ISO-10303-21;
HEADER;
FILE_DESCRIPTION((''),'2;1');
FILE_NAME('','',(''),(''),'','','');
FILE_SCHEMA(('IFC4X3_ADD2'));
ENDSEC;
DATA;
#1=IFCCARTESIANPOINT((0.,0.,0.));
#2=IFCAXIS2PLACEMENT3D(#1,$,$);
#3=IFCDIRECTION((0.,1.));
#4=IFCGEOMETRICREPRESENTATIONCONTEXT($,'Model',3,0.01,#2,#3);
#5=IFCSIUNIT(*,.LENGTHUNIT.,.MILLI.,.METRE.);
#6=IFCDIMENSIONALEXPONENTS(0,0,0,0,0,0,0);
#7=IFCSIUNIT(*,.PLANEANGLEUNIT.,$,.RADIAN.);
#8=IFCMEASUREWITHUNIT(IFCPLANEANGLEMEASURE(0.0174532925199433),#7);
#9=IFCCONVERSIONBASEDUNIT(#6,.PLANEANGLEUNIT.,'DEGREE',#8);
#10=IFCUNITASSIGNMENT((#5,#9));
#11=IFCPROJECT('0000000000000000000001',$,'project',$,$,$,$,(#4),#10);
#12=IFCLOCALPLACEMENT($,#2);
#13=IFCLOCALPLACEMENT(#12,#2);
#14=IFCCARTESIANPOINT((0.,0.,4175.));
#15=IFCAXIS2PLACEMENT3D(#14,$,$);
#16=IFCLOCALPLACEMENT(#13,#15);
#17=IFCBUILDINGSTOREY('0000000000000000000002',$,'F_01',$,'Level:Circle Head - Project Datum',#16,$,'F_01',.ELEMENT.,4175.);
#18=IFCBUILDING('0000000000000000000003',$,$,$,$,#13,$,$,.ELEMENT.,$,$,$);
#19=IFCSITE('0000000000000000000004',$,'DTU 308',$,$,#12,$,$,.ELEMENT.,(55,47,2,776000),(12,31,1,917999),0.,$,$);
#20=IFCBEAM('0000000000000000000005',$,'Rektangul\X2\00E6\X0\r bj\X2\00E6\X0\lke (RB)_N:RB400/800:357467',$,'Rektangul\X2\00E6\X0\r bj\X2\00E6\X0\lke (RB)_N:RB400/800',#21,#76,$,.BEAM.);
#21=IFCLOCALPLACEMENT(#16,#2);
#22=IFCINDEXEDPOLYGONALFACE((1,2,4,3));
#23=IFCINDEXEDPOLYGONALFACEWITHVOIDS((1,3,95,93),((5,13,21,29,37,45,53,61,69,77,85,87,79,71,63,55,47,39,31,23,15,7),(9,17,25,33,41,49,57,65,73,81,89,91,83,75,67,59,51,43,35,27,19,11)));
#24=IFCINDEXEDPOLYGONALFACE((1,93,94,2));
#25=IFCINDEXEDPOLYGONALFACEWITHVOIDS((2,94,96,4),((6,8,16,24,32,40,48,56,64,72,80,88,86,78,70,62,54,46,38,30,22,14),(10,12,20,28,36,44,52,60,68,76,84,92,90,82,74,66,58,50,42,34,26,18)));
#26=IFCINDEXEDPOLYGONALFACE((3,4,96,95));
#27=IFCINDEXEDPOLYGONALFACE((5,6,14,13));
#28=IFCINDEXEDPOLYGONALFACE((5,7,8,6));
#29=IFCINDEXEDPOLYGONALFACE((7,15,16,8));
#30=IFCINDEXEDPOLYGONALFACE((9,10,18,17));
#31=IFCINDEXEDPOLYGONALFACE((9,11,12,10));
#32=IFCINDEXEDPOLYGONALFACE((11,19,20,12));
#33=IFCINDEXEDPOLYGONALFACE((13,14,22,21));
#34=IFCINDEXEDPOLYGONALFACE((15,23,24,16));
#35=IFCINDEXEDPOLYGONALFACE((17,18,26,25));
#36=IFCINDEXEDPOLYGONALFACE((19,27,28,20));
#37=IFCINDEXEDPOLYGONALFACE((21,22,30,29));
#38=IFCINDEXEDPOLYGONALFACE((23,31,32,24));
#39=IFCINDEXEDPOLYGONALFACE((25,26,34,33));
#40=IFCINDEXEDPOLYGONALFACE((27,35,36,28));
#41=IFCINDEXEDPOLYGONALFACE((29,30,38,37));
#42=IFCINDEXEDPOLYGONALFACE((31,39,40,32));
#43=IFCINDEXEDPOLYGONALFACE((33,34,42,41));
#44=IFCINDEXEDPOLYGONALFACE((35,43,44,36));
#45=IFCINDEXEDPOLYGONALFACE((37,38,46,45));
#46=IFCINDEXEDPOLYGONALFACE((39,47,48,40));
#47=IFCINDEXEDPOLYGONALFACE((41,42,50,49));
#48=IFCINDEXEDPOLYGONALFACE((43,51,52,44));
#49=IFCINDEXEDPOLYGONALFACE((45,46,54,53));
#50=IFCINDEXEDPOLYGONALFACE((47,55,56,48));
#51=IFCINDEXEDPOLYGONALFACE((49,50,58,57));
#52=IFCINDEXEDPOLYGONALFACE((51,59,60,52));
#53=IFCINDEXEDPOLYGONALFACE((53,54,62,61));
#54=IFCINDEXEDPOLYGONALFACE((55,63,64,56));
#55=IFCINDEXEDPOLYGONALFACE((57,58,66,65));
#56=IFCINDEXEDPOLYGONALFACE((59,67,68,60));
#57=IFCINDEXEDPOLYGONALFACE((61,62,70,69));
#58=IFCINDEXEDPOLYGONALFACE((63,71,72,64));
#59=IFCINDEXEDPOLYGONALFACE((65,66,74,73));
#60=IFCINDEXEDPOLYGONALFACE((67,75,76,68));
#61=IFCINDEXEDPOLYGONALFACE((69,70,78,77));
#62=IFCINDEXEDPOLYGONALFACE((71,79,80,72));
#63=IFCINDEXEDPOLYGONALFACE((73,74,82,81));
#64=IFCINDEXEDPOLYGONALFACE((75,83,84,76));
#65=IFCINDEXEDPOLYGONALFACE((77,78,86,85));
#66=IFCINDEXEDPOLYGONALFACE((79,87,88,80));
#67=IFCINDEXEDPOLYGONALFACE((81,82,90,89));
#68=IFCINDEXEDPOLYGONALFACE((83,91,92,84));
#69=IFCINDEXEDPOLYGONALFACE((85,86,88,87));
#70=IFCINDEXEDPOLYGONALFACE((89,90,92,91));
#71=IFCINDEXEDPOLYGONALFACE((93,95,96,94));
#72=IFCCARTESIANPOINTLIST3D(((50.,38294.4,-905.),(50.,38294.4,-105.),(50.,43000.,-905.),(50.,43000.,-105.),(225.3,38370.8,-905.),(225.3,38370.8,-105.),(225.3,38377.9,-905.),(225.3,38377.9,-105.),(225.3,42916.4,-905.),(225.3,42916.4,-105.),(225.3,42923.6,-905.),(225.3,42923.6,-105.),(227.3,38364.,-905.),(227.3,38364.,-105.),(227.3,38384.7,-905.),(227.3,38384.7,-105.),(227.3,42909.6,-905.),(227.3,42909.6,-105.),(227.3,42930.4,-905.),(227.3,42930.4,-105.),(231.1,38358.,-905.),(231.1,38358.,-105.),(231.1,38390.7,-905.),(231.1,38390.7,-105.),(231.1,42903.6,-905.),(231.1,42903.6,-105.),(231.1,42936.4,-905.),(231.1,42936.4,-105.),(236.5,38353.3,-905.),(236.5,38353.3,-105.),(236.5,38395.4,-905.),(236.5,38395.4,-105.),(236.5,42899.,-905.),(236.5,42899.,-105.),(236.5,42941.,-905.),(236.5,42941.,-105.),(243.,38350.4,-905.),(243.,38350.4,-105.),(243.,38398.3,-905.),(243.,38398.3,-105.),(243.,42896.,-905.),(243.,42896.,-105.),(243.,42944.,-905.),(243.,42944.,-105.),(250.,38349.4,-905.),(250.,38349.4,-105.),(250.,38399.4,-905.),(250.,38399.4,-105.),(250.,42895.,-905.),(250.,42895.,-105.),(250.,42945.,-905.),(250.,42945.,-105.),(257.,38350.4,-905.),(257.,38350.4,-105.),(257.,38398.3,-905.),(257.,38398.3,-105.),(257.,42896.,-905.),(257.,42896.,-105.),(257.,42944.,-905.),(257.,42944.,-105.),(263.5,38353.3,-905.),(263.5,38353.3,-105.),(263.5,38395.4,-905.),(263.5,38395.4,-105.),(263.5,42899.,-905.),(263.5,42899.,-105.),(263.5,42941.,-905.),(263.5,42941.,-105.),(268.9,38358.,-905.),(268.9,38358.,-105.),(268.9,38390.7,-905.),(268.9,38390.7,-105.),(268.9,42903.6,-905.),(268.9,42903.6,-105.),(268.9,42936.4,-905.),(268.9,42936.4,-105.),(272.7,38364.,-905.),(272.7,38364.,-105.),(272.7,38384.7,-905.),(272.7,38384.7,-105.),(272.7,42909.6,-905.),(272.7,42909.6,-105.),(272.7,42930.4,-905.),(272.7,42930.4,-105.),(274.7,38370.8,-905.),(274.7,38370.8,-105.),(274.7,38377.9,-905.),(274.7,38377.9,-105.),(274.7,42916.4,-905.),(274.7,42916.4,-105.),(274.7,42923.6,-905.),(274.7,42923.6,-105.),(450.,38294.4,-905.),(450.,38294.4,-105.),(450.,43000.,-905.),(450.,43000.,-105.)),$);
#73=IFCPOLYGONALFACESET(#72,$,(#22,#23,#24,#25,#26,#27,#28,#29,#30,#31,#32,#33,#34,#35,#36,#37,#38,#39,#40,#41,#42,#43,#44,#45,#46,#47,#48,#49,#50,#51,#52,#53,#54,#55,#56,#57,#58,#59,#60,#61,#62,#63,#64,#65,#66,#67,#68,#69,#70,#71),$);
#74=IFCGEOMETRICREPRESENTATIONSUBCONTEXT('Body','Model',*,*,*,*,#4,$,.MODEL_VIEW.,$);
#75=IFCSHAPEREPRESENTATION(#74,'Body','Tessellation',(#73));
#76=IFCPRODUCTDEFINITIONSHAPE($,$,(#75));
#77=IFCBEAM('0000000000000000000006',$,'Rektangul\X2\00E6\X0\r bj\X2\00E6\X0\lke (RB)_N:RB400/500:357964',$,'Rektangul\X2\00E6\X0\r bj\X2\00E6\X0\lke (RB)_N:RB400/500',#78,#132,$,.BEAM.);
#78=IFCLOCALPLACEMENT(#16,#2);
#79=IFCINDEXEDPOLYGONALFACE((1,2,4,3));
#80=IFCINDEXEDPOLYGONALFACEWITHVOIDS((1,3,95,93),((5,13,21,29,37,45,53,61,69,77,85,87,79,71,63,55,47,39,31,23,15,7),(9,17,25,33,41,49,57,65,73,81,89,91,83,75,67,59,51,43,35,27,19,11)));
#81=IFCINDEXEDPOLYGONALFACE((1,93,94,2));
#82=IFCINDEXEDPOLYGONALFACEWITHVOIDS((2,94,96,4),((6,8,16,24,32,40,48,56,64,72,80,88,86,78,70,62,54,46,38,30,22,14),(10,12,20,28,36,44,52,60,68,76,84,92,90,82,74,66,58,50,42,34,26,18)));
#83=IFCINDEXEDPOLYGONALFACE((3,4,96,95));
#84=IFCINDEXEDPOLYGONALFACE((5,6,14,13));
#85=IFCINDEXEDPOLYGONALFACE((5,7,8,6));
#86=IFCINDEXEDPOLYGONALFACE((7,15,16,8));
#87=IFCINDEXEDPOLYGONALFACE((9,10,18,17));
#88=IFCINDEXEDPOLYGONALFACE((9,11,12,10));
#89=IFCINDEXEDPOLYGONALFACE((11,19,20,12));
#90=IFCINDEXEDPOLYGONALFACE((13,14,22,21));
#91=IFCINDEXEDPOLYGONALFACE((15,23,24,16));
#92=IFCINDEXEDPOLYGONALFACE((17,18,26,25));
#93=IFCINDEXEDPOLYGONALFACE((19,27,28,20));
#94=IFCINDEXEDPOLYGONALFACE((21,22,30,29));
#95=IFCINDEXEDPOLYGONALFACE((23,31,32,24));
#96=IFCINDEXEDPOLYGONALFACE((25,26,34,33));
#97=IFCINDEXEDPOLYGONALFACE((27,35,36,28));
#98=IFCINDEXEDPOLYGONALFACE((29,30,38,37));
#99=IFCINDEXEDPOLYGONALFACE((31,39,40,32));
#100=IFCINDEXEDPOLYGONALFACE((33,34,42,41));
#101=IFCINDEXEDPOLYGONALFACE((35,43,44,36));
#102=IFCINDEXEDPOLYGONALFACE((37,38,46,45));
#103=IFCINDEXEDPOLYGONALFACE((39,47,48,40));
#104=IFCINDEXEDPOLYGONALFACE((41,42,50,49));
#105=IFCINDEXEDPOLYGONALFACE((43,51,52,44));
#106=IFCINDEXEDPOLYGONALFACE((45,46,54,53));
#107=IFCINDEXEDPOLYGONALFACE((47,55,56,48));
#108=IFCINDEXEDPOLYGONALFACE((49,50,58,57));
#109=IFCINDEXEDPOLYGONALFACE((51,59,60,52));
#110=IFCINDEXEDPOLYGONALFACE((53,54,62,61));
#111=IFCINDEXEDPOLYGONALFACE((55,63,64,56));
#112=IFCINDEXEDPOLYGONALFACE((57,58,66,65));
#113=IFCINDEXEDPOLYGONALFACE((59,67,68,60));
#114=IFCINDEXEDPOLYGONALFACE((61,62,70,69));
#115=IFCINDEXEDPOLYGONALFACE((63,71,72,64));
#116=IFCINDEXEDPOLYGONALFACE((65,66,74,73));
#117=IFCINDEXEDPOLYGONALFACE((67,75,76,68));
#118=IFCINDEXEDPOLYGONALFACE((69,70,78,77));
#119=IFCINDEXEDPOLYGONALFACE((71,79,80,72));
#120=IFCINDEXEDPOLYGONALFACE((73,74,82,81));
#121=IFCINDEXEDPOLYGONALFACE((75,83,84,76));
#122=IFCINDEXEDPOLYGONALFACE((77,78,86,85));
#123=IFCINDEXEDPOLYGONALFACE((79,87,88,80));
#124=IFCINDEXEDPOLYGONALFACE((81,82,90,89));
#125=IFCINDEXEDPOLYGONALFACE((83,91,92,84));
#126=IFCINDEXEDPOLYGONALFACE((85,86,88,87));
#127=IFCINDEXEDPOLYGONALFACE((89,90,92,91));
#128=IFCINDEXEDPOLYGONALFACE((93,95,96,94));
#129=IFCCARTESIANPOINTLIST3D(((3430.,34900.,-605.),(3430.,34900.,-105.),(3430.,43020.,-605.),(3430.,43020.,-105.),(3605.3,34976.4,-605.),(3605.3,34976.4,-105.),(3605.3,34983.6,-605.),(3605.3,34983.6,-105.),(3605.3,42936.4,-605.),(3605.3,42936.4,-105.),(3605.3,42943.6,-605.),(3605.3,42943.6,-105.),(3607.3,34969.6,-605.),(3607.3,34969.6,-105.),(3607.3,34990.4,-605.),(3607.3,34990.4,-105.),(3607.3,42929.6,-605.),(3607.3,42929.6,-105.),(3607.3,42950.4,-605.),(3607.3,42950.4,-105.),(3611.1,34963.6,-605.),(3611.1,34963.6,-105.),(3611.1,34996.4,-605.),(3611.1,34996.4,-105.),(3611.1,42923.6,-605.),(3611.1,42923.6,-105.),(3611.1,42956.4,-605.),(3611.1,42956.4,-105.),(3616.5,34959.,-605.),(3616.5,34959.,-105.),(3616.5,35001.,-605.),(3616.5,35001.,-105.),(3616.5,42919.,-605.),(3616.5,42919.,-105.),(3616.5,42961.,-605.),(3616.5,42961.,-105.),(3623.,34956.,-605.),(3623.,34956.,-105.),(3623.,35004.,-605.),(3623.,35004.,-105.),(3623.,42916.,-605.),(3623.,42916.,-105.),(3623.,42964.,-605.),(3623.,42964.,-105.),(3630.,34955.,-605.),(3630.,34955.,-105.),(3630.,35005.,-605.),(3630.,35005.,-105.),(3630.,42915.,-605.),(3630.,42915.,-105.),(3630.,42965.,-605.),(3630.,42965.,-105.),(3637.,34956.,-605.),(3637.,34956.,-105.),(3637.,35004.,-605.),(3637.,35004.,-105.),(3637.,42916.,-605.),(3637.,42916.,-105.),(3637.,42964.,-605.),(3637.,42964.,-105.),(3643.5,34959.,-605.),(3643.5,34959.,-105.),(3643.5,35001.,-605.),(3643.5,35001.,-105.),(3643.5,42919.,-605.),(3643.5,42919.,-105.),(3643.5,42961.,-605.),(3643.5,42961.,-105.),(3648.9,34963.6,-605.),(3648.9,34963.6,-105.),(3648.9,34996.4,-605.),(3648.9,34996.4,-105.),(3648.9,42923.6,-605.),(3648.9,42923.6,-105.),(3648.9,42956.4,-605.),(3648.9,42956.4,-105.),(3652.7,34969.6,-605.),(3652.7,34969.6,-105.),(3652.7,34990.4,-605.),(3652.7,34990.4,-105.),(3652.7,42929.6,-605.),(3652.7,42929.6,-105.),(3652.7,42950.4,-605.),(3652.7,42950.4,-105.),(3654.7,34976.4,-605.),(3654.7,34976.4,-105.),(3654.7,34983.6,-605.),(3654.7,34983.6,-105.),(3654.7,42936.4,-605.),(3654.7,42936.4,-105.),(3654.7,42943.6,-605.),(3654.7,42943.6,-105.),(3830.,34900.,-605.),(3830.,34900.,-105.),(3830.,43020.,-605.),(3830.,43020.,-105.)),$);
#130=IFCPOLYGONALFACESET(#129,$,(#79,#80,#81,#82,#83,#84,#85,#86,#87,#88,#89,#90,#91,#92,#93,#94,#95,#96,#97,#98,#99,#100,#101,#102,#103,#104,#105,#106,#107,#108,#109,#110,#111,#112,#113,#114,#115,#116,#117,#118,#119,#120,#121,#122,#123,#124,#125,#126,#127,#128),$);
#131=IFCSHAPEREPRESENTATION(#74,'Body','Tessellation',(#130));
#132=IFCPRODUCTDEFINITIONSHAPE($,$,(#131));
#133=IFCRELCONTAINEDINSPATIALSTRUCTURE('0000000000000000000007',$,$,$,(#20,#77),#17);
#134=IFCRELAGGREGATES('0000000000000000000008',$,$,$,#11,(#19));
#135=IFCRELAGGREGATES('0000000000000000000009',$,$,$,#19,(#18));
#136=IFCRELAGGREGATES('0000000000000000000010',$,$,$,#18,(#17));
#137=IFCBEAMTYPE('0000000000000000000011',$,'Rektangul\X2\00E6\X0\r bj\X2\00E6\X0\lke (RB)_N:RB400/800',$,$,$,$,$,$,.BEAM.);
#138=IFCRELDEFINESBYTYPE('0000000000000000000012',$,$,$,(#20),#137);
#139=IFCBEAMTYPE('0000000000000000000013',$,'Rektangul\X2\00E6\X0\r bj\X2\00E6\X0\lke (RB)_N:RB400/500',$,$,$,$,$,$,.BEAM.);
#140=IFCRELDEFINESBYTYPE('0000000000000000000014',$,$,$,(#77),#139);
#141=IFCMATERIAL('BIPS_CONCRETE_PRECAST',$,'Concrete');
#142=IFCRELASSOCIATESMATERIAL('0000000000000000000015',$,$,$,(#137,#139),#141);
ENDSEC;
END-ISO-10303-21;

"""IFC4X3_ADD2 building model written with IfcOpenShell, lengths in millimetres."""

from ifc_helpers import new_model, entity, si_unit, converted_unit, direction, frame, frame_2d, origin, place, context, subcontext, project, spatial, polyline, circle_curve, parameter, trimmed, segment, composite_curve, outline, extrude, source, transform, mapped, material, material_profile, profile_set, type_object, type_shapes, element, save


model = new_model("IFC4X3_ADD2")

# Units and contexts
model_context = context("Model", 3, precision=0.01, world=origin(), true_north=direction((0.0, 1.0)))
body_context = subcontext(model_context, "Body", "Model", "MODEL_VIEW")
ifc_project = project(units=[si_unit("LENGTHUNIT", "METRE", prefix="MILLI"), converted_unit("PLANEANGLEUNIT", "DEGREE", entity("IfcPlaneAngleMeasure", 0.0174532925199433), si_unit("PLANEANGLEUNIT", "RADIAN"), dimensions=[0, 0, 0, 0, 0, 0, 0])], contexts=[model_context])

# Site, building, storey
site_placement = place(None, origin())
site = spatial("IfcSite", under=ifc_project, at=site_placement, Name="DTU 308", CompositionType="ELEMENT", RefLatitude=(55, 47, 2, 776000), RefLongitude=(12, 31, 1, 917999), RefElevation=0.0)
building_placement = place(site_placement, origin())
building = spatial("IfcBuilding", under=site, at=building_placement, CompositionType="ELEMENT")
storey_placement = place(building_placement, frame((0.0, 0.0, 4175.0)))
storey = spatial("IfcBuildingStorey", under=building, at=storey_placement, Name="F_01", ObjectType="Level:Circle Head - Project Datum", LongName="F_01", CompositionType="ELEMENT", Elevation=4175.0)

# Beams
ifc_material_1 = material(Name="BIPS_CONCRETE_PRECAST", Category="Concrete")
ifc_material_profile_1 = material_profile(ifc_material_1, outline(polyline([(-2352.8, -200.0), (2352.8, -200.0), (2352.8, 200.0), (-2352.8, 200.0), (-2352.8, -200.0)]), holes=[composite_curve([segment(trimmed(circle_curve(frame_2d((2272.8, 0.0), x_axis=(-1.0, 0.0)), 25.0), [parameter(0.0)], [parameter(180.0)], True, "PARAMETER"), False, "CONTINUOUS"), segment(trimmed(circle_curve(frame_2d((2272.8, 0.0), x_axis=(-1.0, 0.0)), 25.0), [parameter(180.0)], [parameter(360.0)], True, "PARAMETER"), False, "CONTINUOUS")], self_intersect=False), composite_curve([segment(trimmed(circle_curve(frame_2d((-2272.8, 0.0), x_axis=(-1.0, 0.0)), 25.0), [parameter(0.0)], [parameter(180.0)], True, "PARAMETER"), False, "CONTINUOUS"), segment(trimmed(circle_curve(frame_2d((-2272.8, 0.0), x_axis=(-1.0, 0.0)), 25.0), [parameter(180.0)], [parameter(360.0)], True, "PARAMETER"), False, "CONTINUOUS")], self_intersect=False)]), Name="RB400/800")
ifc_profile_set_1 = profile_set([ifc_material_profile_1], Name="RB400/800")
beam_type_1 = type_object("IfcBeamType", Name="Rektangulær bjælke (RB)_N:RB400/800", PredefinedType="BEAM", material=ifc_profile_set_1)
shared_shape_1 = source(origin(), body_context, "Body", "SweptSolid", [
    extrude(outline(polyline([(-2352.8, -200.0), (2352.8, -200.0), (2352.8, 200.0), (-2352.8, 200.0), (-2352.8, -200.0)]), holes=[composite_curve([segment(trimmed(circle_curve(frame_2d((2272.8, 0.0), x_axis=(-1.0, 0.0)), 25.0), [parameter(0.0)], [parameter(180.0)], True, "PARAMETER"), False, "CONTINUOUS"), segment(trimmed(circle_curve(frame_2d((2272.8, 0.0), x_axis=(-1.0, 0.0)), 25.0), [parameter(180.0)], [parameter(360.0)], True, "PARAMETER"), False, "CONTINUOUS")], self_intersect=False), composite_curve([segment(trimmed(circle_curve(frame_2d((-2272.8, 0.0), x_axis=(-1.0, 0.0)), 25.0), [parameter(0.0)], [parameter(180.0)], True, "PARAMETER"), False, "CONTINUOUS"), segment(trimmed(circle_curve(frame_2d((-2272.8, 0.0), x_axis=(-1.0, 0.0)), 25.0), [parameter(180.0)], [parameter(360.0)], True, "PARAMETER"), False, "CONTINUOUS")], self_intersect=False)]), frame((-16.7, 0.0, -400.0), z_axis=(0.0, 0.0, 1.0), x_axis=(-1.0, 0.0, 0.0)), (0.0, 0.0, 1.0), 800.0),
])
type_shapes(beam_type_1, [shared_shape_1])
beam_1_placement = place(storey_placement, frame((250.0, 40663.8, -505.0), z_axis=(0.0, 0.0, 1.0), x_axis=(0.0, 1.0, 0.0)))
element("IfcBeam", 1, at=beam_1_placement, inside=storey, type_object=beam_type_1, Name="Rektangulær bjælke (RB)_N:RB400/800:357467", ObjectType="Rektangulær bjælke (RB)_N:RB400/800", PredefinedType="BEAM", context=body_context, shape_type="MappedRepresentation", body=[
    mapped(shared_shape_1, transform((0.0, 0.0, 0.0), scale=1.0)),
])
ifc_material_profile_2 = material_profile(ifc_material_1, outline(polyline([(-4060.0, -200.0), (4060.0, -200.0), (4060.0, 200.0), (-4060.0, 200.0), (-4060.0, -200.0)]), holes=[composite_curve([segment(trimmed(circle_curve(frame_2d((3980.0, 0.0), x_axis=(-1.0, 0.0)), 25.0), [parameter(0.0)], [parameter(180.0)], True, "PARAMETER"), False, "CONTINUOUS"), segment(trimmed(circle_curve(frame_2d((3980.0, 0.0), x_axis=(-1.0, 0.0)), 25.0), [parameter(180.0)], [parameter(360.0)], True, "PARAMETER"), False, "CONTINUOUS")], self_intersect=False), composite_curve([segment(trimmed(circle_curve(frame_2d((-3980.0, 0.0), x_axis=(-1.0, 0.0)), 25.0), [parameter(0.0)], [parameter(180.0)], True, "PARAMETER"), False, "CONTINUOUS"), segment(trimmed(circle_curve(frame_2d((-3980.0, 0.0), x_axis=(-1.0, 0.0)), 25.0), [parameter(180.0)], [parameter(360.0)], True, "PARAMETER"), False, "CONTINUOUS")], self_intersect=False)]), Name="RB400/500")
ifc_profile_set_2 = profile_set([ifc_material_profile_2], Name="RB400/500")
beam_type_2 = type_object("IfcBeamType", Name="Rektangulær bjælke (RB)_N:RB400/500", PredefinedType="BEAM", material=ifc_profile_set_2)
shared_shape_2 = source(origin(), body_context, "Body", "SweptSolid", [
    extrude(outline(polyline([(-4060.0, -200.0), (4060.0, -200.0), (4060.0, 200.0), (-4060.0, 200.0), (-4060.0, -200.0)]), holes=[composite_curve([segment(trimmed(circle_curve(frame_2d((3980.0, 0.0), x_axis=(-1.0, 0.0)), 25.0), [parameter(0.0)], [parameter(180.0)], True, "PARAMETER"), False, "CONTINUOUS"), segment(trimmed(circle_curve(frame_2d((3980.0, 0.0), x_axis=(-1.0, 0.0)), 25.0), [parameter(180.0)], [parameter(360.0)], True, "PARAMETER"), False, "CONTINUOUS")], self_intersect=False), composite_curve([segment(trimmed(circle_curve(frame_2d((-3980.0, 0.0), x_axis=(-1.0, 0.0)), 25.0), [parameter(0.0)], [parameter(180.0)], True, "PARAMETER"), False, "CONTINUOUS"), segment(trimmed(circle_curve(frame_2d((-3980.0, 0.0), x_axis=(-1.0, 0.0)), 25.0), [parameter(180.0)], [parameter(360.0)], True, "PARAMETER"), False, "CONTINUOUS")], self_intersect=False)]), frame((10.0, 0.0, -250.0), z_axis=(0.0, 0.0, 1.0), x_axis=(-1.0, 0.0, 0.0)), (0.0, 0.0, 1.0), 500.0),
])
type_shapes(beam_type_2, [shared_shape_2])
beam_2_placement = place(storey_placement, frame((3630.0, 38970.0, -355.0), z_axis=(0.0, 0.0, 1.0), x_axis=(0.0, -1.0, 0.0)))
element("IfcBeam", 2, at=beam_2_placement, inside=storey, type_object=beam_type_2, Name="Rektangulær bjælke (RB)_N:RB400/500:357964", ObjectType="Rektangulær bjælke (RB)_N:RB400/500", PredefinedType="BEAM", context=body_context, shape_type="MappedRepresentation", body=[
    mapped(shared_shape_2, transform((0.0, 0.0, 0.0), scale=1.0)),
])

save(model, "model.ifc")
